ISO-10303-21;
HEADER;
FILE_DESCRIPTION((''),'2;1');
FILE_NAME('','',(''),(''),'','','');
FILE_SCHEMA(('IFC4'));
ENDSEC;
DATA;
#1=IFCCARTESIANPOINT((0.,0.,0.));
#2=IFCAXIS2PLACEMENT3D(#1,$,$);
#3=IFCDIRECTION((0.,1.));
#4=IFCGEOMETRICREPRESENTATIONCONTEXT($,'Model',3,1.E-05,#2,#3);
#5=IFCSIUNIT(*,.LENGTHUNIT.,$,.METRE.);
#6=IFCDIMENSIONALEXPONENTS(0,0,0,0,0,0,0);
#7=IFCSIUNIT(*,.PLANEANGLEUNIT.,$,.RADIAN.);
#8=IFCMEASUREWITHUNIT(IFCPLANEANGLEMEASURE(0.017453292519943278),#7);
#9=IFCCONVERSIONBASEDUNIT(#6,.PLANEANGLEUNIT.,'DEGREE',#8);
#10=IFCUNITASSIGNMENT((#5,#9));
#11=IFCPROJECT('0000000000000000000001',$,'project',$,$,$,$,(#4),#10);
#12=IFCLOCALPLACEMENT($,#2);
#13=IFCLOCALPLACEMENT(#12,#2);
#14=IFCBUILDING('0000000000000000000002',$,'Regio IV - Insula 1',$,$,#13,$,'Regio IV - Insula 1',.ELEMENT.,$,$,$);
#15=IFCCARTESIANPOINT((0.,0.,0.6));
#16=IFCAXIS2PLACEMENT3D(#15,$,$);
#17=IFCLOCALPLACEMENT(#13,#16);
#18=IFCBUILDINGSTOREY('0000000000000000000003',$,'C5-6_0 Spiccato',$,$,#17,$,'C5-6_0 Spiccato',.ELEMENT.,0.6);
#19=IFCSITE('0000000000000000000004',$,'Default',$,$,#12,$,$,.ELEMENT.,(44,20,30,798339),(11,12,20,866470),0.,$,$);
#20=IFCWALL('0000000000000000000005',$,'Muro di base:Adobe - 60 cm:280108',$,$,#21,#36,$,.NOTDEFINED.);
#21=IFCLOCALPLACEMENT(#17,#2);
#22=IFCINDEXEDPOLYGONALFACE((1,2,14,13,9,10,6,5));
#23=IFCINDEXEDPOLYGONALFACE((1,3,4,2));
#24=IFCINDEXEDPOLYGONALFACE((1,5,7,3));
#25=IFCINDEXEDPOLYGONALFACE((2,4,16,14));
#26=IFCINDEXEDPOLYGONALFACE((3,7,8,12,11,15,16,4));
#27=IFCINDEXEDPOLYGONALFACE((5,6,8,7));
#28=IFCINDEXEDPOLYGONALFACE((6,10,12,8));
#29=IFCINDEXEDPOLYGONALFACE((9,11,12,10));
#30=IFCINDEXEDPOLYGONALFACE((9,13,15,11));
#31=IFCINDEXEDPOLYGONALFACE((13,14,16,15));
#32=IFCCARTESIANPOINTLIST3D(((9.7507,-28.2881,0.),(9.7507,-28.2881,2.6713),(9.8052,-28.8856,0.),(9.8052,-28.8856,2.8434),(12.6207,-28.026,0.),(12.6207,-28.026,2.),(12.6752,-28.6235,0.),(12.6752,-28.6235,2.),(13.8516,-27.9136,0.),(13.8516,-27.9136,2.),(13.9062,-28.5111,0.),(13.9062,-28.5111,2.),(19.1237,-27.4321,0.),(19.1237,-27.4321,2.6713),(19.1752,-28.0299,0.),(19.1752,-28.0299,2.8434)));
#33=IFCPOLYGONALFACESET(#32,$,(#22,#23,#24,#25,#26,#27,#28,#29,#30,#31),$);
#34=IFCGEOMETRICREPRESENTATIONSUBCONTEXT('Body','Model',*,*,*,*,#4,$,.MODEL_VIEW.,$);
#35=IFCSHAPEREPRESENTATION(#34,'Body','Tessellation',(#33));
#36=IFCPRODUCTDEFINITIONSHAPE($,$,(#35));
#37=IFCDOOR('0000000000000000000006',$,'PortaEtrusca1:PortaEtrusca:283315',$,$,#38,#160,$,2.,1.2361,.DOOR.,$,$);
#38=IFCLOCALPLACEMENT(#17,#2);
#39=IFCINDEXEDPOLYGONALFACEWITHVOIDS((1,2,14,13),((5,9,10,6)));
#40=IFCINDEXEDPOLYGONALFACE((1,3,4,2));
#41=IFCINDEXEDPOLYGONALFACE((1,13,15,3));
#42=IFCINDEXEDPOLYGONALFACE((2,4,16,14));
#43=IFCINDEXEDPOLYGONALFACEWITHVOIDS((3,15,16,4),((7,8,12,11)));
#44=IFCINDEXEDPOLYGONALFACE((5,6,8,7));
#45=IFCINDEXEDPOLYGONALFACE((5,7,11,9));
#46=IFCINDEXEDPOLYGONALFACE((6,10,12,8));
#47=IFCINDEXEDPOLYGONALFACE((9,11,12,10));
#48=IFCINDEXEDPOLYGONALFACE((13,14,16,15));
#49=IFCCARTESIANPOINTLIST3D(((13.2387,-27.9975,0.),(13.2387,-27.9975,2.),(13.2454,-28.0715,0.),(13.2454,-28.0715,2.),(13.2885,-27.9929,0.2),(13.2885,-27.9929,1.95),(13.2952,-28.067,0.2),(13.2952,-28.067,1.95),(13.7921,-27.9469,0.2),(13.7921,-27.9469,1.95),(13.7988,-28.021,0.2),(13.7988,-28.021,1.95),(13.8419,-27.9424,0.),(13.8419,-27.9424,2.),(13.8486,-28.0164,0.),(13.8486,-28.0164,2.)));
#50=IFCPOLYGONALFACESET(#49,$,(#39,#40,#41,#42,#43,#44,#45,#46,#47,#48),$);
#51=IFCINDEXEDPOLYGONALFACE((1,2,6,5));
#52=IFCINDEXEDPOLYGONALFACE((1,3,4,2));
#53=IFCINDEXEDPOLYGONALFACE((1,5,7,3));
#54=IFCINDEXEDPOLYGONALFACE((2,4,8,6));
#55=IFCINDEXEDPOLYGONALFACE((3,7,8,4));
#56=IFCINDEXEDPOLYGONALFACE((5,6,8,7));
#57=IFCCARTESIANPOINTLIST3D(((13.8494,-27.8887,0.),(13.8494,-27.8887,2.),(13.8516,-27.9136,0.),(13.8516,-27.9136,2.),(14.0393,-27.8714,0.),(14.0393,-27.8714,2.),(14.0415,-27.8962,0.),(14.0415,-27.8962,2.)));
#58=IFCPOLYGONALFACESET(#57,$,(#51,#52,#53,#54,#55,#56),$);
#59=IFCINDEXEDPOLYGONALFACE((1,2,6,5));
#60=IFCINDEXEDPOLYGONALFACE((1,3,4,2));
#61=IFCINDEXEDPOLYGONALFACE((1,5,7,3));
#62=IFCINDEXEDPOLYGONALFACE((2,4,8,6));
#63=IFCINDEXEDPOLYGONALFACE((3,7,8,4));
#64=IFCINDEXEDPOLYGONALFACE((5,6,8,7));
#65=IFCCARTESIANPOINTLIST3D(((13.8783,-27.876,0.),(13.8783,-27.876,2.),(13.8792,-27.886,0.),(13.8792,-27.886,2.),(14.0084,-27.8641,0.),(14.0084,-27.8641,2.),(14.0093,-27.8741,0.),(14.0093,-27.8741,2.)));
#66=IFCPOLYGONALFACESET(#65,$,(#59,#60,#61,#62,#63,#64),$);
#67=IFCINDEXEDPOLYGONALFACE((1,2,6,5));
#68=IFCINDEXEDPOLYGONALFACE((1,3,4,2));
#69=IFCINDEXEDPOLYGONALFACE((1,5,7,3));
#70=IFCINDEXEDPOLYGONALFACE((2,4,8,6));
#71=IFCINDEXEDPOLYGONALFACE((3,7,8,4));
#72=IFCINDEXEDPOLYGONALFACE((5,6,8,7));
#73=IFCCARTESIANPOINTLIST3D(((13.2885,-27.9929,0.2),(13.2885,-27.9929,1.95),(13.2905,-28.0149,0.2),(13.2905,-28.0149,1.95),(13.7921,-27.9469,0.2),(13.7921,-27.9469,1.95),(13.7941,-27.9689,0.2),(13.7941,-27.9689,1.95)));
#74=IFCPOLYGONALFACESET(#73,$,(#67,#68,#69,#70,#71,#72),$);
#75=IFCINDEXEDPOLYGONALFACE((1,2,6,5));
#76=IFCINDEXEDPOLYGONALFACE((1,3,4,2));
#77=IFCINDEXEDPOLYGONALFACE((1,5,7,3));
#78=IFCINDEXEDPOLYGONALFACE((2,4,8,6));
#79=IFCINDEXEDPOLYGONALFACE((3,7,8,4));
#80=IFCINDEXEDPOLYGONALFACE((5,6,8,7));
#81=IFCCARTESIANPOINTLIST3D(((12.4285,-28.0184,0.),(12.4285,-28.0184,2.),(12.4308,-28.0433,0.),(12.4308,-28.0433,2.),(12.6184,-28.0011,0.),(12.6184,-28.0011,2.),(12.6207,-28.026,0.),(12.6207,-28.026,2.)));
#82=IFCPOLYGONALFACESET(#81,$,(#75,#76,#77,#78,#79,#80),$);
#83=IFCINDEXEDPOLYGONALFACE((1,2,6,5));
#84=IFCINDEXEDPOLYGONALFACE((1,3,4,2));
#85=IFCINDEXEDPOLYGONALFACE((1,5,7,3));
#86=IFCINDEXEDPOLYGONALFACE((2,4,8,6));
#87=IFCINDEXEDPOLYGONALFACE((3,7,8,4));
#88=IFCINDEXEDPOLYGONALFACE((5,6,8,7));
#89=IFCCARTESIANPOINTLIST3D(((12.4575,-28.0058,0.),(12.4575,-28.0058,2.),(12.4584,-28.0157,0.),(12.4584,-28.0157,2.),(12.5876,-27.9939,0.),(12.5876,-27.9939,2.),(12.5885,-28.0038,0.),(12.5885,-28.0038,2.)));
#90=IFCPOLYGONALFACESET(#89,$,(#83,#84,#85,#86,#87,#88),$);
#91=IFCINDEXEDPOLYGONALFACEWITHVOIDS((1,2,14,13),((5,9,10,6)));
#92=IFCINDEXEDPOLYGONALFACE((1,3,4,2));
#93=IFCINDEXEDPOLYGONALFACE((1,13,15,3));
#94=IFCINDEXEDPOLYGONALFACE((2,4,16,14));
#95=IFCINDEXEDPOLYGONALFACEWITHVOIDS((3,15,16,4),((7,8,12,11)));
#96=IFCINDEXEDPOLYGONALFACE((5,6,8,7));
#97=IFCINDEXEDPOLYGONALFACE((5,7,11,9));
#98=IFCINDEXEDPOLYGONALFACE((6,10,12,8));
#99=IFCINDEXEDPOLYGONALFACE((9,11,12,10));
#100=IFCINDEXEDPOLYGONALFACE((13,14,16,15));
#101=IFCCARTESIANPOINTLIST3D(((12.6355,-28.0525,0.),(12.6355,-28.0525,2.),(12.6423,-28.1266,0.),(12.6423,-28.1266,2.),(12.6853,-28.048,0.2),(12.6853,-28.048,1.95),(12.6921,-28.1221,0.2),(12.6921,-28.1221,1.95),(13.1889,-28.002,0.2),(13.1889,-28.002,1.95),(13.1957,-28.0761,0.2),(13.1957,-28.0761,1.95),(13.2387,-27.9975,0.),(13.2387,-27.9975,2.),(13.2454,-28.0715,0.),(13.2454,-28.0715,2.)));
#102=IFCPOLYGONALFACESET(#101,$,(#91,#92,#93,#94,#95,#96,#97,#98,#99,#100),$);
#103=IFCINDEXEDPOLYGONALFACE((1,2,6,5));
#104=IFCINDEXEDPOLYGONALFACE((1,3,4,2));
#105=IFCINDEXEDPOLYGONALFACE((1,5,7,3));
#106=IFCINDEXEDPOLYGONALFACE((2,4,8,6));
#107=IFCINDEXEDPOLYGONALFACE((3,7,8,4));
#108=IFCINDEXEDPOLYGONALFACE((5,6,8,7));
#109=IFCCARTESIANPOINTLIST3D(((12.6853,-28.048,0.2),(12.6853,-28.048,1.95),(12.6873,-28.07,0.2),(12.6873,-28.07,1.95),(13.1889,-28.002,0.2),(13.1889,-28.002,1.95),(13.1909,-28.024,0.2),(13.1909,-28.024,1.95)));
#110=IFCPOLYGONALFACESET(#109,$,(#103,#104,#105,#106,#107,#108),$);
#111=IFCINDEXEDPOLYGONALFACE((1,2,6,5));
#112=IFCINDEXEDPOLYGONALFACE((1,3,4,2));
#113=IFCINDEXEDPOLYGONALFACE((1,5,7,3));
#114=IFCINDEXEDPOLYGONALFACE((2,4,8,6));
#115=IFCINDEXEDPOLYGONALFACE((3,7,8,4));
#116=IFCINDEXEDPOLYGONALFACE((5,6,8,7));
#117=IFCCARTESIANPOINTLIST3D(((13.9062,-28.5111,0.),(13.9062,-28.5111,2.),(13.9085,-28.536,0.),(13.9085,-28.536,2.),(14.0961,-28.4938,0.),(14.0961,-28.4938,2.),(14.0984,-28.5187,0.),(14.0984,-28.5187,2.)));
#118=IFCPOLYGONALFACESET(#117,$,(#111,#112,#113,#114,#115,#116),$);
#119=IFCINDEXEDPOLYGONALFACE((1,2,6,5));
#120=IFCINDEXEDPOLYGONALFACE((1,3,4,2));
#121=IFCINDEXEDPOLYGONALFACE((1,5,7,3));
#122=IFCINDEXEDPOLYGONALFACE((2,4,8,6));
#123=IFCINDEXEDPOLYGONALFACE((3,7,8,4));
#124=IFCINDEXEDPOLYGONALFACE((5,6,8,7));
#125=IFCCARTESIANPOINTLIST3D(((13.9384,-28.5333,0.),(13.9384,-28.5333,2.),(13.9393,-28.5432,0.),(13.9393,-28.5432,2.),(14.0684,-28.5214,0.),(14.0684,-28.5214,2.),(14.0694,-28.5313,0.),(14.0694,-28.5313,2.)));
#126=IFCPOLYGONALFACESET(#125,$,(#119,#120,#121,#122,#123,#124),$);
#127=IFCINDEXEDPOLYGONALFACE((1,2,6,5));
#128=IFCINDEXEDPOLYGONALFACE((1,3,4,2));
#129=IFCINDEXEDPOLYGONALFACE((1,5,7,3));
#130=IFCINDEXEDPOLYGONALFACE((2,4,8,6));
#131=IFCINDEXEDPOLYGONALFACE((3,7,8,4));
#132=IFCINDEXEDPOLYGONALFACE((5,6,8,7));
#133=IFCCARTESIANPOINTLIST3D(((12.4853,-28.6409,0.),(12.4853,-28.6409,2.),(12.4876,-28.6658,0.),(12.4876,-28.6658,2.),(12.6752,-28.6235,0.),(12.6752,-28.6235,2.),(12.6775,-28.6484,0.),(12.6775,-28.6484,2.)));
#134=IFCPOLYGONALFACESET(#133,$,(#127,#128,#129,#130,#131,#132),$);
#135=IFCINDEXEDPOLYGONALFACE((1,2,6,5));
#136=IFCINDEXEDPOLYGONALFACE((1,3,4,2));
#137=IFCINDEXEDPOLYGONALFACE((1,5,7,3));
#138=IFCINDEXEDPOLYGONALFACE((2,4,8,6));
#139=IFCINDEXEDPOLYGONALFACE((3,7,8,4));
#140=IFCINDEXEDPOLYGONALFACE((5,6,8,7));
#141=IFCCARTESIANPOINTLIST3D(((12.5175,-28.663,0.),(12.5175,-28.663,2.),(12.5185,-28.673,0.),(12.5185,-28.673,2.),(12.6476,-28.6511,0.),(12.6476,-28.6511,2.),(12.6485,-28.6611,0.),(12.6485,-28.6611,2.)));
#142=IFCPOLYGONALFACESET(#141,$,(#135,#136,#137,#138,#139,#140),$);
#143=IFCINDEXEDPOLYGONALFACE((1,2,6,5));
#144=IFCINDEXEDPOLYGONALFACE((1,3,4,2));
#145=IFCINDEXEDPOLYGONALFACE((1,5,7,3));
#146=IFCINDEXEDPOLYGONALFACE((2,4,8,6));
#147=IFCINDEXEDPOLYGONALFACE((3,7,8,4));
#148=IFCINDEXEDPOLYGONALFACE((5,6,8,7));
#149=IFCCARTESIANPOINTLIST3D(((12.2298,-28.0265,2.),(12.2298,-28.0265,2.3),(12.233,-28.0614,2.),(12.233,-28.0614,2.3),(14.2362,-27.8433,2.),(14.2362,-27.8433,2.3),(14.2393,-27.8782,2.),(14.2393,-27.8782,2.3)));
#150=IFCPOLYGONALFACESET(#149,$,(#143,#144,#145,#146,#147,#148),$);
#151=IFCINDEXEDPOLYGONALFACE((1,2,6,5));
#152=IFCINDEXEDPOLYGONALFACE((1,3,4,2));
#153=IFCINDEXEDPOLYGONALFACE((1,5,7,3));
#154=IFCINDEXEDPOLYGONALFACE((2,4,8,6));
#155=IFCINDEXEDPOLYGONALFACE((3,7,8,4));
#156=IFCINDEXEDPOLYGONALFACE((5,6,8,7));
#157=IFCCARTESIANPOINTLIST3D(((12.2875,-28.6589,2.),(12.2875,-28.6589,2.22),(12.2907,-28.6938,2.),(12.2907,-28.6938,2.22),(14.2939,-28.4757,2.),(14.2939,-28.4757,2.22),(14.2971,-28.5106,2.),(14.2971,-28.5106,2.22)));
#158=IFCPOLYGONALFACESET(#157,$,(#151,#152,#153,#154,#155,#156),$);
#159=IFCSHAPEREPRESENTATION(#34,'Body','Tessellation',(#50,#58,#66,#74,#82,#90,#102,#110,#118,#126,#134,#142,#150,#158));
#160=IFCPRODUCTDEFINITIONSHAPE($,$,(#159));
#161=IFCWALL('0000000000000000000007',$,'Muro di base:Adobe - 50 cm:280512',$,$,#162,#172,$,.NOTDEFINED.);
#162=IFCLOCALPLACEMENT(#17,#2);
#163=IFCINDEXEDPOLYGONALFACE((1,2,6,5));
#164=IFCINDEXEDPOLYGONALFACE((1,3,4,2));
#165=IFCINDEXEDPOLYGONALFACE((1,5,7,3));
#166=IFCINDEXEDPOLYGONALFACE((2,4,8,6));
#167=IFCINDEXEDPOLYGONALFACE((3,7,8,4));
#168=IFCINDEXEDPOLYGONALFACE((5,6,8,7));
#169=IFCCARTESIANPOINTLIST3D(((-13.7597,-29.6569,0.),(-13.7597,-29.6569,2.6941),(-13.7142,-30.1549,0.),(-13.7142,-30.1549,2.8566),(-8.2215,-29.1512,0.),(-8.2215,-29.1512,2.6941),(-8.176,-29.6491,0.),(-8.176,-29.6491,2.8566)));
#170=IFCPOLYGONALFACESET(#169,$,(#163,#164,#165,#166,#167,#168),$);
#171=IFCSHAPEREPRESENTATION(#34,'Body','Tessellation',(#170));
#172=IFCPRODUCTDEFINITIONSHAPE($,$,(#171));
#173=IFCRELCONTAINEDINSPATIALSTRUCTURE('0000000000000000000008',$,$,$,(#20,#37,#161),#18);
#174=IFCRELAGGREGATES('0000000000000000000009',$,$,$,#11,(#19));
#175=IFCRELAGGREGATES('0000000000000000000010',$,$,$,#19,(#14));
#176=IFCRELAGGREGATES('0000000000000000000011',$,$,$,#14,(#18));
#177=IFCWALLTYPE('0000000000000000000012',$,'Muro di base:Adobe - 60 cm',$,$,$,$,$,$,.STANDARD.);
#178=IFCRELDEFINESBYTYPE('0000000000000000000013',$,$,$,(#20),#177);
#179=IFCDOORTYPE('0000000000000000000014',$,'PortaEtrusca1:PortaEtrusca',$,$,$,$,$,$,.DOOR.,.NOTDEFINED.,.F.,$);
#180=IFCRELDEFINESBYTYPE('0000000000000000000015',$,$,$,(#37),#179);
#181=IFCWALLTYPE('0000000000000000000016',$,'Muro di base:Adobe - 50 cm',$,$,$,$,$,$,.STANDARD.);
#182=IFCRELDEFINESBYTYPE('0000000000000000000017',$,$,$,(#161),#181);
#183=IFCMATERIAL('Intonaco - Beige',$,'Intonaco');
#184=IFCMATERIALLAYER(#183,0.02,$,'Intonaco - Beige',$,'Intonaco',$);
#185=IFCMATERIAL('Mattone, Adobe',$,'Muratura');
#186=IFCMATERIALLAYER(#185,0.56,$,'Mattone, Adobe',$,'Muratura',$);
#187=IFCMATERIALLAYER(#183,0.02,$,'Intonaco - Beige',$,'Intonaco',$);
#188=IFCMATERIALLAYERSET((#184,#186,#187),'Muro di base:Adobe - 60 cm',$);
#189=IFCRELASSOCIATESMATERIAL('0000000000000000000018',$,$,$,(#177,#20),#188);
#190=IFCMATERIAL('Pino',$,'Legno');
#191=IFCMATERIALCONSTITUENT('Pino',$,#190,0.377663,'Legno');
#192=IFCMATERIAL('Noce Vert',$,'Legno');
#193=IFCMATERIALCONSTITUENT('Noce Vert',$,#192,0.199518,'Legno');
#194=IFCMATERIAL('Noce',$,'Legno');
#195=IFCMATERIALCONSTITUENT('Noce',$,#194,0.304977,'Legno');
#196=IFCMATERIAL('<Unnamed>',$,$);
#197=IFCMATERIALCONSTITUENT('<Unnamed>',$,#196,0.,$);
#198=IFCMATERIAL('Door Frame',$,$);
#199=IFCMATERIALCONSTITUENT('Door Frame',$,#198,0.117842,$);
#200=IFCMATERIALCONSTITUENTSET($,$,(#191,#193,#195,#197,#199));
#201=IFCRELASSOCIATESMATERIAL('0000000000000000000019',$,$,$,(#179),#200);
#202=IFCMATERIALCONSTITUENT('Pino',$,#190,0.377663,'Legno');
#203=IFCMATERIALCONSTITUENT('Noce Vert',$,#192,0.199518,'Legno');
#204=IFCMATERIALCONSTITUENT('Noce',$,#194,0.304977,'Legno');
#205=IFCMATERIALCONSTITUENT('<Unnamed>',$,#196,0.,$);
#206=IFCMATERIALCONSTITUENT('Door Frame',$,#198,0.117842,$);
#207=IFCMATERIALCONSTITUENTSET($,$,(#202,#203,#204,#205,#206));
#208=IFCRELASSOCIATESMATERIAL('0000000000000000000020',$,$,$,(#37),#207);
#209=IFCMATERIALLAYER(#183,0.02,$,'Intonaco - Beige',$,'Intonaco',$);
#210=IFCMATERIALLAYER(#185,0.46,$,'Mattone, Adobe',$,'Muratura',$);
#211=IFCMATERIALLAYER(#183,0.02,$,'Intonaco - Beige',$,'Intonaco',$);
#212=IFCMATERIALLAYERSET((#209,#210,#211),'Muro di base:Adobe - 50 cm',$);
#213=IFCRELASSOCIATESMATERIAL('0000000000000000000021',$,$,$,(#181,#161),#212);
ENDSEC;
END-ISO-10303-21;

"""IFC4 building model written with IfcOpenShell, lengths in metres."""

from ifc_helpers import new_model, entity, si_unit, converted_unit, direction, frame, frame_2d, origin, origin_2d_with_axis, place, context, subcontext, project, spatial, polyline, rectangle, outline, extrude, clip, bounded_halfspace, source, transform, mapped, material, layer, layer_set, layer_usage, constituent, constituent_set, type_object, type_shapes, element, fill, save


model = new_model("IFC4")

# Units and contexts
model_context = context("Model", 3, precision=1e-05, world=origin(), true_north=direction((0.0, 1.0)))
body_context = subcontext(model_context, "Body", "Model", "MODEL_VIEW")
ifc_project = project(units=[si_unit("LENGTHUNIT", "METRE"), converted_unit("PLANEANGLEUNIT", "DEGREE", entity("IfcPlaneAngleMeasure", 0.017453292519943278), si_unit("PLANEANGLEUNIT", "RADIAN"), dimensions=[0, 0, 0, 0, 0, 0, 0])], contexts=[model_context])

# Site, building, storey
site_placement = place(None, origin())
site = spatial("IfcSite", under=ifc_project, at=site_placement, Name="Default", CompositionType="ELEMENT", RefLatitude=(44, 20, 30, 798339), RefLongitude=(11, 12, 20, 866470), RefElevation=0.0)
building_placement = place(site_placement, origin())
building = spatial("IfcBuilding", under=site, at=building_placement, Name="Regio IV - Insula 1", LongName="Regio IV - Insula 1", CompositionType="ELEMENT")
storey_placement = place(building_placement, frame((0.0, 0.0, 0.6)))
storey = spatial("IfcBuildingStorey", under=building, at=storey_placement, Name="C5-6_0 Spiccato", LongName="C5-6_0 Spiccato", CompositionType="ELEMENT", Elevation=0.6)

# Shared definitions
ifc_material_1 = material(Name="Intonaco - Beige", Category="Intonaco")
ifc_layer_1 = layer(ifc_material_1, 0.02, Name="Intonaco - Beige", Category="Intonaco")
ifc_material_2 = material(Name="Mattone, Adobe", Category="Muratura")
ifc_layer_2 = layer(ifc_material_2, 0.56, Name="Mattone, Adobe", Category="Muratura")
ifc_layer_3 = layer(ifc_material_1, 0.02, Name="Intonaco - Beige", Category="Intonaco")
ifc_layer_set_1 = layer_set([ifc_layer_1, ifc_layer_2, ifc_layer_3], Name="Muro di base:Adobe - 60 cm")
wall_type_1 = type_object("IfcWallType", Name="Muro di base:Adobe - 60 cm", PredefinedType="STANDARD", material=ifc_layer_set_1)

# Shared definitions
ifc_material_3 = material(Name="Pino", Category="Legno")
ifc_material_4 = material(Name="Noce Vert", Category="Legno")
ifc_material_5 = material(Name="Noce", Category="Legno")
ifc_material_6 = material(Name="<Unnamed>")
ifc_material_7 = material(Name="Door Frame")
ifc_constituent_1 = constituent(ifc_material_3, Name="Pino", Category="Legno", fraction=0.377663)
ifc_constituent_2 = constituent(ifc_material_4, Name="Noce Vert", Category="Legno", fraction=0.199518)
ifc_constituent_3 = constituent(ifc_material_5, Name="Noce", Category="Legno", fraction=0.304977)
ifc_constituent_4 = constituent(ifc_material_6, Name="<Unnamed>", fraction=0.0)
ifc_constituent_5 = constituent(ifc_material_7, Name="Door Frame", fraction=0.117842)
ifc_constituent_set_1 = constituent_set(constituents=[ifc_constituent_1, ifc_constituent_2, ifc_constituent_3, ifc_constituent_4, ifc_constituent_5])
door_type_1 = type_object("IfcDoorType", Name="PortaEtrusca1:PortaEtrusca", OperationType="NOTDEFINED", ParameterTakesPrecedence=False, PredefinedType="DOOR", material=ifc_constituent_set_1)
shared_shape_1 = source(origin(), body_context, "Body", "SweptSolid", [
    extrude(outline(polyline([(-1.0, -0.3028), (1.0, -0.3028), (1.0, 0.3028), (-1.0, 0.3028), (-1.0, -0.3028)]), holes=[polyline([(-0.95, 0.2528), (0.8, 0.2528), (0.8, -0.2528), (-0.95, -0.2528), (-0.95, 0.2528)])]), frame((0.3152, 0.0278, 1.0), z_axis=(0.0, 1.0, 0.0), x_axis=(0.0, 0.0, -1.0)), (0.0, 0.0, 1.0), 0.0744),
    extrude(rectangle(XDim=0.025, YDim=0.1907, at=frame_2d((0.0, 0.0), x_axis=(1.0, 0.0))), frame((-0.0953, -0.0125, 0.0), z_axis=(0.0, 0.0, 1.0), x_axis=(0.0, 1.0, 0.0)), (0.0, 0.0, 1.0), 2.0),
    extrude(rectangle(XDim=0.01, YDim=0.1306, at=frame_2d((0.0, 0.0), x_axis=(1.0, 0.0))), frame((-0.0953, -0.03, 0.0), z_axis=(0.0, 0.0, 1.0), x_axis=(0.0, 1.0, 0.0)), (0.0, 0.0, 1.0), 2.0),
    extrude(rectangle(XDim=0.0221, YDim=0.5057, at=frame_2d((0.0, 0.0), x_axis=(1.0, 0.0))), frame((0.3152, 0.0388, 0.2), z_axis=(0.0, 0.0, 1.0), x_axis=(0.0, 1.0, 0.0)), (0.0, 0.0, 1.0), 1.75),
    extrude(rectangle(XDim=0.025, YDim=0.1907, at=frame_2d((0.0, 0.0), x_axis=(1.0, 0.0))), frame((1.3314, -0.0125, 0.0), z_axis=(0.0, 0.0, 1.0), x_axis=(0.0, 1.0, 0.0)), (0.0, 0.0, 1.0), 2.0),
    extrude(rectangle(XDim=0.01, YDim=0.1306, at=frame_2d((0.0, 0.0), x_axis=(1.0, 0.0))), frame((1.3314, -0.03, 0.0), z_axis=(0.0, 0.0, 1.0), x_axis=(0.0, 1.0, 0.0)), (0.0, 0.0, 1.0), 2.0),
    extrude(outline(polyline([(-0.3028, -1.0), (0.3028, -1.0), (0.3028, 1.0), (-0.3028, 1.0), (-0.3028, -1.0)]), holes=[polyline([(0.2528, -0.95), (-0.2528, -0.95), (-0.2528, 0.8), (0.2528, 0.8), (0.2528, -0.95)])]), frame((0.9209, 0.0278, 1.0), z_axis=(0.0, 1.0, 0.0), x_axis=(1.0, 0.0, 0.0)), (0.0, 0.0, 1.0), 0.0744),
    extrude(rectangle(XDim=0.0221, YDim=0.5057, at=frame_2d((0.0, 0.0), x_axis=(1.0, 0.0))), frame((0.9209, 0.0388, 0.2), z_axis=(0.0, 0.0, 1.0), x_axis=(0.0, 1.0, 0.0)), (0.0, 0.0, 1.0), 1.75),
    extrude(rectangle(XDim=0.025, YDim=0.1907, at=frame_2d((0.0, 0.0), x_axis=(1.0, 0.0))), frame((-0.0953, 0.6125, 0.0), z_axis=(0.0, 0.0, 1.0), x_axis=(0.0, -1.0, 0.0)), (0.0, 0.0, 1.0), 2.0),
    extrude(rectangle(XDim=0.01, YDim=0.1306, at=origin_2d_with_axis()), frame((-0.0953, 0.63, 0.0), z_axis=(0.0, 0.0, 1.0), x_axis=(0.0, -1.0, 0.0)), (0.0, 0.0, 1.0), 2.0),
    extrude(rectangle(XDim=0.025, YDim=0.1907, at=frame_2d((0.0, 0.0), x_axis=(1.0, 0.0))), frame((1.3314, 0.6125, 0.0), z_axis=(0.0, 0.0, 1.0), x_axis=(0.0, -1.0, 0.0)), (0.0, 0.0, 1.0), 2.0),
    extrude(rectangle(XDim=0.01, YDim=0.1306, at=origin_2d_with_axis()), frame((1.3314, 0.63, 0.0), z_axis=(0.0, 0.0, 1.0), x_axis=(0.0, -1.0, 0.0)), (0.0, 0.0, 1.0), 2.0),
    extrude(rectangle(XDim=0.035, YDim=2.0147, at=frame_2d((0.0, 0.0), x_axis=(1.0, 0.0))), frame((0.618, -0.0175, 2.0), z_axis=(0.0, 0.0, 1.0), x_axis=(0.0, 1.0, 0.0)), (0.0, 0.0, 1.0), 0.3),
    extrude(rectangle(XDim=0.035, YDim=2.0147, at=frame_2d((0.0, 0.0), x_axis=(1.0, 0.0))), frame((0.618, 0.6175, 2.0), z_axis=(0.0, 0.0, 1.0), x_axis=(0.0, -1.0, 0.0)), (0.0, 0.0, 1.0), 0.22),
])
type_shapes(door_type_1, [shared_shape_1])

# Wall, opening, door
ifc_layer_usage_1 = layer_usage(ifc_layer_set_1, "AXIS2", "NEGATIVE", 0.3)
wall_1_placement = place(storey_placement, frame((19.151, -27.7309, 0.0), z_axis=(0.0, 0.0, 1.0), x_axis=(-0.995856, -0.090941, 0.0)))
wall_1 = element("IfcWall", 1, at=wall_1_placement, inside=storey, type_object=wall_type_1, material=ifc_layer_usage_1, Name="Muro di base:Adobe - 60 cm:280108", PredefinedType="NOTDEFINED", context=body_context, shape_type="Clipping", body=[
    clip(extrude(outline(polyline([(0.0, -0.3), (9.4121, -0.3), (9.4121, 0.3), (0.0031, 0.3), (0.0, -0.3)])), origin(), (0.0, 0.0, 1.0), 2.8434), bounded_halfspace(frame((0.0, -0.3, 2.6713), z_axis=(0.0, -0.275637, 0.961262), x_axis=(1.0, 0.0, 0.0)), False, frame((0.0, -0.3, 2.6713)), polyline([(0.0, 0.0), (9.4121, 0.0), (9.4121, 0.6), (0.0031, 0.6), (0.0, 0.0)]))),
])
opening_1_placement = place(wall_1_placement, frame((5.294, -0.3, 0.0)))
opening_1 = element("IfcOpeningElement", 2, at=opening_1_placement, cuts=wall_1, PredefinedType="OPENING", context=body_context, shape_type="SweptSolid", body=[
    extrude(rectangle(XDim=2.0, YDim=1.2361, at=frame_2d((1.0, 0.618), x_axis=(1.0, 0.0))), frame((0.0, 0.0, 0.0), z_axis=(0.0, 1.0, 0.0), x_axis=(0.0, 0.0, 1.0)), (0.0, 0.0, 1.0), 0.6),
])
ifc_constituent_6 = constituent(ifc_material_3, Name="Pino", Category="Legno", fraction=0.377663)
ifc_constituent_7 = constituent(ifc_material_4, Name="Noce Vert", Category="Legno", fraction=0.199518)
ifc_constituent_8 = constituent(ifc_material_5, Name="Noce", Category="Legno", fraction=0.304977)
ifc_constituent_9 = constituent(ifc_material_6, Name="<Unnamed>", fraction=0.0)
ifc_constituent_10 = constituent(ifc_material_7, Name="Door Frame", fraction=0.117842)
ifc_constituent_set_2 = constituent_set(constituents=[ifc_constituent_6, ifc_constituent_7, ifc_constituent_8, ifc_constituent_9, ifc_constituent_10])
door_1_placement = place(opening_1_placement, origin())
door_1 = element("IfcDoor", 3, at=door_1_placement, inside=storey, type_object=door_type_1, material=ifc_constituent_set_2, Name="PortaEtrusca1:PortaEtrusca:283315", OverallHeight=2.0, OverallWidth=1.2361, PredefinedType="DOOR", context=body_context, shape_type="MappedRepresentation", body=[
    mapped(shared_shape_1, transform((0.0, 0.0, 0.0), scale=1.0)),
])
fill(opening_1, door_1)

# Wall
ifc_layer_4 = layer(ifc_material_1, 0.02, Name="Intonaco - Beige", Category="Intonaco")
ifc_layer_5 = layer(ifc_material_2, 0.46, Name="Mattone, Adobe", Category="Muratura")
ifc_layer_6 = layer(ifc_material_1, 0.02, Name="Intonaco - Beige", Category="Intonaco")
ifc_layer_set_2 = layer_set([ifc_layer_4, ifc_layer_5, ifc_layer_6], Name="Muro di base:Adobe - 50 cm")
wall_type_2 = type_object("IfcWallType", Name="Muro di base:Adobe - 50 cm", PredefinedType="STANDARD", material=ifc_layer_set_2)
ifc_layer_usage_2 = layer_usage(ifc_layer_set_2, "AXIS2", "NEGATIVE", 0.25)
wall_2_placement = place(storey_placement, frame((-13.737, -29.9059, 0.0), z_axis=(0.0, 0.0, 1.0), x_axis=(0.995856, 0.090941, 0.0)))
element("IfcWall", 4, at=wall_2_placement, inside=storey, type_object=wall_type_2, material=ifc_layer_usage_2, Name="Muro di base:Adobe - 50 cm:280512", PredefinedType="NOTDEFINED", context=body_context, shape_type="Clipping", body=[
    clip(extrude(rectangle(XDim=5.5612, YDim=0.5, at=frame_2d((2.7806, 0.0), x_axis=(-1.0, 0.0))), origin(), (0.0, 0.0, 1.0), 2.8566), bounded_halfspace(frame((0.0, -0.25, 2.8566), z_axis=(0.0, 0.309017, 0.951057), x_axis=(-1.0, 0.0, 0.0)), False, frame((0.0, -0.25, 2.8566)), polyline([(0.0, 0.0), (0.5, 0.0), (5.0612, 0.0), (5.5612, 0.0), (5.5612, 0.5), (0.0, 0.5), (0.0, 0.0)]))),
])

save(model, "model.ifc")
